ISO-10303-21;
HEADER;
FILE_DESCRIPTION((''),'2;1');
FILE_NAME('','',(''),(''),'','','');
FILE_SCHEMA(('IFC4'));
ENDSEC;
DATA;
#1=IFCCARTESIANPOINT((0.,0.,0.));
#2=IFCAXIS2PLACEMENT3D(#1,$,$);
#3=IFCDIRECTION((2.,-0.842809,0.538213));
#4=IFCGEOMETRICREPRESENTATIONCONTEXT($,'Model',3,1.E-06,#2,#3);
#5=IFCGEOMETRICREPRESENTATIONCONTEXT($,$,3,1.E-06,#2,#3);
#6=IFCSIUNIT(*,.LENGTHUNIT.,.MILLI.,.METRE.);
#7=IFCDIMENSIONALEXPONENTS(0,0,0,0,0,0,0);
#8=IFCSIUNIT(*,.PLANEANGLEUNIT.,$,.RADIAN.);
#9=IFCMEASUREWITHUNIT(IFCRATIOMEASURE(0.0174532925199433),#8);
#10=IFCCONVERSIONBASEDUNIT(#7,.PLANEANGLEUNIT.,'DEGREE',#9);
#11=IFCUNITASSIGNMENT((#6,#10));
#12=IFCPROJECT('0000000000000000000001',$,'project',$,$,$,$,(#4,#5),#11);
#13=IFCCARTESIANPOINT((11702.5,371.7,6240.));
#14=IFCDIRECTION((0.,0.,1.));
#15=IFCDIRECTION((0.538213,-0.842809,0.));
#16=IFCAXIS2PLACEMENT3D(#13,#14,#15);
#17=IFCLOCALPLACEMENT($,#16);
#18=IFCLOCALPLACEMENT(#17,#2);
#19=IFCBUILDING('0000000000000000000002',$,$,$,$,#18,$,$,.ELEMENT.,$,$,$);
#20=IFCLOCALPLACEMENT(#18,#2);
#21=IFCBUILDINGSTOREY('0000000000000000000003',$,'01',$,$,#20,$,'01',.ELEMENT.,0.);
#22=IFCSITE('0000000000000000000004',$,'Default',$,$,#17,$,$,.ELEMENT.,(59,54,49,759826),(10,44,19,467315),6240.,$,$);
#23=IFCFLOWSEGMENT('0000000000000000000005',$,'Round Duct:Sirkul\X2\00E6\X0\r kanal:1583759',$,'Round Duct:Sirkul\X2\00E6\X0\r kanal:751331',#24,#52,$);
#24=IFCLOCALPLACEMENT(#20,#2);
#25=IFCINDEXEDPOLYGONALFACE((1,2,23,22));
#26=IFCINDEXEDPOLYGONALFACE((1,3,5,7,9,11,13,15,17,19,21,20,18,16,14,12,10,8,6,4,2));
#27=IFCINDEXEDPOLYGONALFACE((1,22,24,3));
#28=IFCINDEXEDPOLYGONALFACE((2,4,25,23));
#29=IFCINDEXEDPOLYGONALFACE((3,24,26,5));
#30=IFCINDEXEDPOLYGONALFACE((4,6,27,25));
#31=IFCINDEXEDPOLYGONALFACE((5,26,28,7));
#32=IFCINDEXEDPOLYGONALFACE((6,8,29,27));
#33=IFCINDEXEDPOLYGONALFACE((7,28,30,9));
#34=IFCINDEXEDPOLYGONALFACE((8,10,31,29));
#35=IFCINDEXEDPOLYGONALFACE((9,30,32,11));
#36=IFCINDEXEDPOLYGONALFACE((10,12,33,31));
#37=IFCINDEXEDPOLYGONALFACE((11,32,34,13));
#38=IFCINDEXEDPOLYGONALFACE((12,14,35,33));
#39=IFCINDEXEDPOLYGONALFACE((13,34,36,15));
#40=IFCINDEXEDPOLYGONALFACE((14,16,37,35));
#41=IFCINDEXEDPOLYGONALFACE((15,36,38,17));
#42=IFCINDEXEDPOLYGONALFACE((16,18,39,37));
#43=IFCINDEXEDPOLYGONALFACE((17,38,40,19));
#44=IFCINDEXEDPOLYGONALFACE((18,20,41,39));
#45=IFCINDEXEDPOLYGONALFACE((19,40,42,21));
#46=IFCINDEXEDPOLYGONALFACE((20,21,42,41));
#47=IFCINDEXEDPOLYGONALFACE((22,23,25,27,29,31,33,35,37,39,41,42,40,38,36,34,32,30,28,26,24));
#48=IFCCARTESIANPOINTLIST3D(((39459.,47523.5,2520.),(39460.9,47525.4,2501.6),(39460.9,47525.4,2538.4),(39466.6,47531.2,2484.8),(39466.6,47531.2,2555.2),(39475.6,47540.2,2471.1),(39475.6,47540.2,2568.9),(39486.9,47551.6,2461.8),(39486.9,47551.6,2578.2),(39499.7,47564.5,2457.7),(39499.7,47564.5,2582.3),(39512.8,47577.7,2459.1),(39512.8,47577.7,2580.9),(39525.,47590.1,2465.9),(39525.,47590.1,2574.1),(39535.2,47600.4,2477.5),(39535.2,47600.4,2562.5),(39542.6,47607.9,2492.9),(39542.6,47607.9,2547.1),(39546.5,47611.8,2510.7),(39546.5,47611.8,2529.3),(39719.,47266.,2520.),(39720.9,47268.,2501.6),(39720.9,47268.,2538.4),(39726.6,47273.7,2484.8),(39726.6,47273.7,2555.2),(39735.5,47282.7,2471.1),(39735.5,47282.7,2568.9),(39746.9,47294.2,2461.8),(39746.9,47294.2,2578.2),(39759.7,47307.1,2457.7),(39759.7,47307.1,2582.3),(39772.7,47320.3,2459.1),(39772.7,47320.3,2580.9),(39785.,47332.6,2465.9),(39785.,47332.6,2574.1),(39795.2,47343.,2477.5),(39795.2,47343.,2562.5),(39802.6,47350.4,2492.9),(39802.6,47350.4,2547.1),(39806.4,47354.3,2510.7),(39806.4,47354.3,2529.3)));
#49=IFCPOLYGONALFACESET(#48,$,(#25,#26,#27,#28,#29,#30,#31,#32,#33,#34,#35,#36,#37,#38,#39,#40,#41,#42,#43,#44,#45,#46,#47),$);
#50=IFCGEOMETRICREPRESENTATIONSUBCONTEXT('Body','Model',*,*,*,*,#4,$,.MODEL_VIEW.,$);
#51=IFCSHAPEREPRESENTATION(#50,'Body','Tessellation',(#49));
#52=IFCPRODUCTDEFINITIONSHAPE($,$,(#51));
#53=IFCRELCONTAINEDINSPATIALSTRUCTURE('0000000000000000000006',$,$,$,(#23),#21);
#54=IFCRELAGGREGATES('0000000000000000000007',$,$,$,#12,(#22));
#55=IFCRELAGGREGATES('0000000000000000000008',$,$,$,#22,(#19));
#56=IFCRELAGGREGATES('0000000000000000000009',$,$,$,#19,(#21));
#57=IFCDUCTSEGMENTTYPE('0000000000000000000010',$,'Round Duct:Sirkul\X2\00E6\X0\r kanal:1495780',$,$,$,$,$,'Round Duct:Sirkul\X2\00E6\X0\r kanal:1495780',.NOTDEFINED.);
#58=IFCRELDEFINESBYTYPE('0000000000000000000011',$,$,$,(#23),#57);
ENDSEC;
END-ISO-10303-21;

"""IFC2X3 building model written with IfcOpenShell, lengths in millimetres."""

from ifc_helpers import new_model, entity, si_unit, converted_unit, direction, frame, origin, origin_2d_with_axis, place, context, subcontext, project, spatial, circle, extrude, type_object, element, save


model = new_model("IFC2X3")

# Units and contexts
model_context = context("Model", 3, precision=1e-06, world=origin(), true_north=direction((2.0, -0.842809, 0.538213)))
context_of_model = context(None, 3, precision=1e-06, world=origin(), true_north=direction((2.0, -0.842809, 0.538213)))
body_context = subcontext(model_context, "Body", "Model", "MODEL_VIEW")
ifc_project = project(units=[si_unit("LENGTHUNIT", "METRE", prefix="MILLI"), converted_unit("PLANEANGLEUNIT", "DEGREE", entity("IfcRatioMeasure", 0.0174532925199433), si_unit("PLANEANGLEUNIT", "RADIAN"), dimensions=[0, 0, 0, 0, 0, 0, 0])], contexts=[model_context, context_of_model])

# Site, building, storey
site_placement = place(None, frame((11702.5, 371.7, 6240.0), z_axis=(0.0, 0.0, 1.0), x_axis=(0.538213, -0.842809, 0.0)))
site = spatial("IfcSite", under=ifc_project, at=site_placement, Name="Default", CompositionType="ELEMENT", RefLatitude=(59, 54, 49, 759826), RefLongitude=(10, 44, 19, 467315), RefElevation=6240.0)
building_placement = place(site_placement, origin())
building = spatial("IfcBuilding", under=site, at=building_placement, CompositionType="ELEMENT")
storey_placement = place(building_placement, origin())
storey = spatial("IfcBuildingStorey", under=building, at=storey_placement, Name="01", LongName="01", CompositionType="ELEMENT", Elevation=0.0)

# Flow segment
duct_segment_type = type_object("IfcDuctSegmentType", Name="Round Duct:Sirkulær kanal:1495780", ElementType="Round Duct:Sirkulær kanal:1495780", PredefinedType="NOTDEFINED")
flow_segment_1_placement = place(storey_placement, origin())
element("IfcFlowSegment", 1, at=flow_segment_1_placement, inside=storey, type_object=duct_segment_type, Name="Round Duct:Sirkulær kanal:1583759", ObjectType="Round Duct:Sirkulær kanal:751331", context=body_context, shape_type="SweptSolid", body=[
    extrude(circle(Radius=62.5, at=origin_2d_with_axis()), frame((39503.0, 47567.9, 2520.0), z_axis=(0.710554, -0.703643, 0.0), x_axis=(-0.703643, -0.710554, 0.0)), (0.0, 0.0, 1.0), 365.9),
])

save(model, "model.ifc")
